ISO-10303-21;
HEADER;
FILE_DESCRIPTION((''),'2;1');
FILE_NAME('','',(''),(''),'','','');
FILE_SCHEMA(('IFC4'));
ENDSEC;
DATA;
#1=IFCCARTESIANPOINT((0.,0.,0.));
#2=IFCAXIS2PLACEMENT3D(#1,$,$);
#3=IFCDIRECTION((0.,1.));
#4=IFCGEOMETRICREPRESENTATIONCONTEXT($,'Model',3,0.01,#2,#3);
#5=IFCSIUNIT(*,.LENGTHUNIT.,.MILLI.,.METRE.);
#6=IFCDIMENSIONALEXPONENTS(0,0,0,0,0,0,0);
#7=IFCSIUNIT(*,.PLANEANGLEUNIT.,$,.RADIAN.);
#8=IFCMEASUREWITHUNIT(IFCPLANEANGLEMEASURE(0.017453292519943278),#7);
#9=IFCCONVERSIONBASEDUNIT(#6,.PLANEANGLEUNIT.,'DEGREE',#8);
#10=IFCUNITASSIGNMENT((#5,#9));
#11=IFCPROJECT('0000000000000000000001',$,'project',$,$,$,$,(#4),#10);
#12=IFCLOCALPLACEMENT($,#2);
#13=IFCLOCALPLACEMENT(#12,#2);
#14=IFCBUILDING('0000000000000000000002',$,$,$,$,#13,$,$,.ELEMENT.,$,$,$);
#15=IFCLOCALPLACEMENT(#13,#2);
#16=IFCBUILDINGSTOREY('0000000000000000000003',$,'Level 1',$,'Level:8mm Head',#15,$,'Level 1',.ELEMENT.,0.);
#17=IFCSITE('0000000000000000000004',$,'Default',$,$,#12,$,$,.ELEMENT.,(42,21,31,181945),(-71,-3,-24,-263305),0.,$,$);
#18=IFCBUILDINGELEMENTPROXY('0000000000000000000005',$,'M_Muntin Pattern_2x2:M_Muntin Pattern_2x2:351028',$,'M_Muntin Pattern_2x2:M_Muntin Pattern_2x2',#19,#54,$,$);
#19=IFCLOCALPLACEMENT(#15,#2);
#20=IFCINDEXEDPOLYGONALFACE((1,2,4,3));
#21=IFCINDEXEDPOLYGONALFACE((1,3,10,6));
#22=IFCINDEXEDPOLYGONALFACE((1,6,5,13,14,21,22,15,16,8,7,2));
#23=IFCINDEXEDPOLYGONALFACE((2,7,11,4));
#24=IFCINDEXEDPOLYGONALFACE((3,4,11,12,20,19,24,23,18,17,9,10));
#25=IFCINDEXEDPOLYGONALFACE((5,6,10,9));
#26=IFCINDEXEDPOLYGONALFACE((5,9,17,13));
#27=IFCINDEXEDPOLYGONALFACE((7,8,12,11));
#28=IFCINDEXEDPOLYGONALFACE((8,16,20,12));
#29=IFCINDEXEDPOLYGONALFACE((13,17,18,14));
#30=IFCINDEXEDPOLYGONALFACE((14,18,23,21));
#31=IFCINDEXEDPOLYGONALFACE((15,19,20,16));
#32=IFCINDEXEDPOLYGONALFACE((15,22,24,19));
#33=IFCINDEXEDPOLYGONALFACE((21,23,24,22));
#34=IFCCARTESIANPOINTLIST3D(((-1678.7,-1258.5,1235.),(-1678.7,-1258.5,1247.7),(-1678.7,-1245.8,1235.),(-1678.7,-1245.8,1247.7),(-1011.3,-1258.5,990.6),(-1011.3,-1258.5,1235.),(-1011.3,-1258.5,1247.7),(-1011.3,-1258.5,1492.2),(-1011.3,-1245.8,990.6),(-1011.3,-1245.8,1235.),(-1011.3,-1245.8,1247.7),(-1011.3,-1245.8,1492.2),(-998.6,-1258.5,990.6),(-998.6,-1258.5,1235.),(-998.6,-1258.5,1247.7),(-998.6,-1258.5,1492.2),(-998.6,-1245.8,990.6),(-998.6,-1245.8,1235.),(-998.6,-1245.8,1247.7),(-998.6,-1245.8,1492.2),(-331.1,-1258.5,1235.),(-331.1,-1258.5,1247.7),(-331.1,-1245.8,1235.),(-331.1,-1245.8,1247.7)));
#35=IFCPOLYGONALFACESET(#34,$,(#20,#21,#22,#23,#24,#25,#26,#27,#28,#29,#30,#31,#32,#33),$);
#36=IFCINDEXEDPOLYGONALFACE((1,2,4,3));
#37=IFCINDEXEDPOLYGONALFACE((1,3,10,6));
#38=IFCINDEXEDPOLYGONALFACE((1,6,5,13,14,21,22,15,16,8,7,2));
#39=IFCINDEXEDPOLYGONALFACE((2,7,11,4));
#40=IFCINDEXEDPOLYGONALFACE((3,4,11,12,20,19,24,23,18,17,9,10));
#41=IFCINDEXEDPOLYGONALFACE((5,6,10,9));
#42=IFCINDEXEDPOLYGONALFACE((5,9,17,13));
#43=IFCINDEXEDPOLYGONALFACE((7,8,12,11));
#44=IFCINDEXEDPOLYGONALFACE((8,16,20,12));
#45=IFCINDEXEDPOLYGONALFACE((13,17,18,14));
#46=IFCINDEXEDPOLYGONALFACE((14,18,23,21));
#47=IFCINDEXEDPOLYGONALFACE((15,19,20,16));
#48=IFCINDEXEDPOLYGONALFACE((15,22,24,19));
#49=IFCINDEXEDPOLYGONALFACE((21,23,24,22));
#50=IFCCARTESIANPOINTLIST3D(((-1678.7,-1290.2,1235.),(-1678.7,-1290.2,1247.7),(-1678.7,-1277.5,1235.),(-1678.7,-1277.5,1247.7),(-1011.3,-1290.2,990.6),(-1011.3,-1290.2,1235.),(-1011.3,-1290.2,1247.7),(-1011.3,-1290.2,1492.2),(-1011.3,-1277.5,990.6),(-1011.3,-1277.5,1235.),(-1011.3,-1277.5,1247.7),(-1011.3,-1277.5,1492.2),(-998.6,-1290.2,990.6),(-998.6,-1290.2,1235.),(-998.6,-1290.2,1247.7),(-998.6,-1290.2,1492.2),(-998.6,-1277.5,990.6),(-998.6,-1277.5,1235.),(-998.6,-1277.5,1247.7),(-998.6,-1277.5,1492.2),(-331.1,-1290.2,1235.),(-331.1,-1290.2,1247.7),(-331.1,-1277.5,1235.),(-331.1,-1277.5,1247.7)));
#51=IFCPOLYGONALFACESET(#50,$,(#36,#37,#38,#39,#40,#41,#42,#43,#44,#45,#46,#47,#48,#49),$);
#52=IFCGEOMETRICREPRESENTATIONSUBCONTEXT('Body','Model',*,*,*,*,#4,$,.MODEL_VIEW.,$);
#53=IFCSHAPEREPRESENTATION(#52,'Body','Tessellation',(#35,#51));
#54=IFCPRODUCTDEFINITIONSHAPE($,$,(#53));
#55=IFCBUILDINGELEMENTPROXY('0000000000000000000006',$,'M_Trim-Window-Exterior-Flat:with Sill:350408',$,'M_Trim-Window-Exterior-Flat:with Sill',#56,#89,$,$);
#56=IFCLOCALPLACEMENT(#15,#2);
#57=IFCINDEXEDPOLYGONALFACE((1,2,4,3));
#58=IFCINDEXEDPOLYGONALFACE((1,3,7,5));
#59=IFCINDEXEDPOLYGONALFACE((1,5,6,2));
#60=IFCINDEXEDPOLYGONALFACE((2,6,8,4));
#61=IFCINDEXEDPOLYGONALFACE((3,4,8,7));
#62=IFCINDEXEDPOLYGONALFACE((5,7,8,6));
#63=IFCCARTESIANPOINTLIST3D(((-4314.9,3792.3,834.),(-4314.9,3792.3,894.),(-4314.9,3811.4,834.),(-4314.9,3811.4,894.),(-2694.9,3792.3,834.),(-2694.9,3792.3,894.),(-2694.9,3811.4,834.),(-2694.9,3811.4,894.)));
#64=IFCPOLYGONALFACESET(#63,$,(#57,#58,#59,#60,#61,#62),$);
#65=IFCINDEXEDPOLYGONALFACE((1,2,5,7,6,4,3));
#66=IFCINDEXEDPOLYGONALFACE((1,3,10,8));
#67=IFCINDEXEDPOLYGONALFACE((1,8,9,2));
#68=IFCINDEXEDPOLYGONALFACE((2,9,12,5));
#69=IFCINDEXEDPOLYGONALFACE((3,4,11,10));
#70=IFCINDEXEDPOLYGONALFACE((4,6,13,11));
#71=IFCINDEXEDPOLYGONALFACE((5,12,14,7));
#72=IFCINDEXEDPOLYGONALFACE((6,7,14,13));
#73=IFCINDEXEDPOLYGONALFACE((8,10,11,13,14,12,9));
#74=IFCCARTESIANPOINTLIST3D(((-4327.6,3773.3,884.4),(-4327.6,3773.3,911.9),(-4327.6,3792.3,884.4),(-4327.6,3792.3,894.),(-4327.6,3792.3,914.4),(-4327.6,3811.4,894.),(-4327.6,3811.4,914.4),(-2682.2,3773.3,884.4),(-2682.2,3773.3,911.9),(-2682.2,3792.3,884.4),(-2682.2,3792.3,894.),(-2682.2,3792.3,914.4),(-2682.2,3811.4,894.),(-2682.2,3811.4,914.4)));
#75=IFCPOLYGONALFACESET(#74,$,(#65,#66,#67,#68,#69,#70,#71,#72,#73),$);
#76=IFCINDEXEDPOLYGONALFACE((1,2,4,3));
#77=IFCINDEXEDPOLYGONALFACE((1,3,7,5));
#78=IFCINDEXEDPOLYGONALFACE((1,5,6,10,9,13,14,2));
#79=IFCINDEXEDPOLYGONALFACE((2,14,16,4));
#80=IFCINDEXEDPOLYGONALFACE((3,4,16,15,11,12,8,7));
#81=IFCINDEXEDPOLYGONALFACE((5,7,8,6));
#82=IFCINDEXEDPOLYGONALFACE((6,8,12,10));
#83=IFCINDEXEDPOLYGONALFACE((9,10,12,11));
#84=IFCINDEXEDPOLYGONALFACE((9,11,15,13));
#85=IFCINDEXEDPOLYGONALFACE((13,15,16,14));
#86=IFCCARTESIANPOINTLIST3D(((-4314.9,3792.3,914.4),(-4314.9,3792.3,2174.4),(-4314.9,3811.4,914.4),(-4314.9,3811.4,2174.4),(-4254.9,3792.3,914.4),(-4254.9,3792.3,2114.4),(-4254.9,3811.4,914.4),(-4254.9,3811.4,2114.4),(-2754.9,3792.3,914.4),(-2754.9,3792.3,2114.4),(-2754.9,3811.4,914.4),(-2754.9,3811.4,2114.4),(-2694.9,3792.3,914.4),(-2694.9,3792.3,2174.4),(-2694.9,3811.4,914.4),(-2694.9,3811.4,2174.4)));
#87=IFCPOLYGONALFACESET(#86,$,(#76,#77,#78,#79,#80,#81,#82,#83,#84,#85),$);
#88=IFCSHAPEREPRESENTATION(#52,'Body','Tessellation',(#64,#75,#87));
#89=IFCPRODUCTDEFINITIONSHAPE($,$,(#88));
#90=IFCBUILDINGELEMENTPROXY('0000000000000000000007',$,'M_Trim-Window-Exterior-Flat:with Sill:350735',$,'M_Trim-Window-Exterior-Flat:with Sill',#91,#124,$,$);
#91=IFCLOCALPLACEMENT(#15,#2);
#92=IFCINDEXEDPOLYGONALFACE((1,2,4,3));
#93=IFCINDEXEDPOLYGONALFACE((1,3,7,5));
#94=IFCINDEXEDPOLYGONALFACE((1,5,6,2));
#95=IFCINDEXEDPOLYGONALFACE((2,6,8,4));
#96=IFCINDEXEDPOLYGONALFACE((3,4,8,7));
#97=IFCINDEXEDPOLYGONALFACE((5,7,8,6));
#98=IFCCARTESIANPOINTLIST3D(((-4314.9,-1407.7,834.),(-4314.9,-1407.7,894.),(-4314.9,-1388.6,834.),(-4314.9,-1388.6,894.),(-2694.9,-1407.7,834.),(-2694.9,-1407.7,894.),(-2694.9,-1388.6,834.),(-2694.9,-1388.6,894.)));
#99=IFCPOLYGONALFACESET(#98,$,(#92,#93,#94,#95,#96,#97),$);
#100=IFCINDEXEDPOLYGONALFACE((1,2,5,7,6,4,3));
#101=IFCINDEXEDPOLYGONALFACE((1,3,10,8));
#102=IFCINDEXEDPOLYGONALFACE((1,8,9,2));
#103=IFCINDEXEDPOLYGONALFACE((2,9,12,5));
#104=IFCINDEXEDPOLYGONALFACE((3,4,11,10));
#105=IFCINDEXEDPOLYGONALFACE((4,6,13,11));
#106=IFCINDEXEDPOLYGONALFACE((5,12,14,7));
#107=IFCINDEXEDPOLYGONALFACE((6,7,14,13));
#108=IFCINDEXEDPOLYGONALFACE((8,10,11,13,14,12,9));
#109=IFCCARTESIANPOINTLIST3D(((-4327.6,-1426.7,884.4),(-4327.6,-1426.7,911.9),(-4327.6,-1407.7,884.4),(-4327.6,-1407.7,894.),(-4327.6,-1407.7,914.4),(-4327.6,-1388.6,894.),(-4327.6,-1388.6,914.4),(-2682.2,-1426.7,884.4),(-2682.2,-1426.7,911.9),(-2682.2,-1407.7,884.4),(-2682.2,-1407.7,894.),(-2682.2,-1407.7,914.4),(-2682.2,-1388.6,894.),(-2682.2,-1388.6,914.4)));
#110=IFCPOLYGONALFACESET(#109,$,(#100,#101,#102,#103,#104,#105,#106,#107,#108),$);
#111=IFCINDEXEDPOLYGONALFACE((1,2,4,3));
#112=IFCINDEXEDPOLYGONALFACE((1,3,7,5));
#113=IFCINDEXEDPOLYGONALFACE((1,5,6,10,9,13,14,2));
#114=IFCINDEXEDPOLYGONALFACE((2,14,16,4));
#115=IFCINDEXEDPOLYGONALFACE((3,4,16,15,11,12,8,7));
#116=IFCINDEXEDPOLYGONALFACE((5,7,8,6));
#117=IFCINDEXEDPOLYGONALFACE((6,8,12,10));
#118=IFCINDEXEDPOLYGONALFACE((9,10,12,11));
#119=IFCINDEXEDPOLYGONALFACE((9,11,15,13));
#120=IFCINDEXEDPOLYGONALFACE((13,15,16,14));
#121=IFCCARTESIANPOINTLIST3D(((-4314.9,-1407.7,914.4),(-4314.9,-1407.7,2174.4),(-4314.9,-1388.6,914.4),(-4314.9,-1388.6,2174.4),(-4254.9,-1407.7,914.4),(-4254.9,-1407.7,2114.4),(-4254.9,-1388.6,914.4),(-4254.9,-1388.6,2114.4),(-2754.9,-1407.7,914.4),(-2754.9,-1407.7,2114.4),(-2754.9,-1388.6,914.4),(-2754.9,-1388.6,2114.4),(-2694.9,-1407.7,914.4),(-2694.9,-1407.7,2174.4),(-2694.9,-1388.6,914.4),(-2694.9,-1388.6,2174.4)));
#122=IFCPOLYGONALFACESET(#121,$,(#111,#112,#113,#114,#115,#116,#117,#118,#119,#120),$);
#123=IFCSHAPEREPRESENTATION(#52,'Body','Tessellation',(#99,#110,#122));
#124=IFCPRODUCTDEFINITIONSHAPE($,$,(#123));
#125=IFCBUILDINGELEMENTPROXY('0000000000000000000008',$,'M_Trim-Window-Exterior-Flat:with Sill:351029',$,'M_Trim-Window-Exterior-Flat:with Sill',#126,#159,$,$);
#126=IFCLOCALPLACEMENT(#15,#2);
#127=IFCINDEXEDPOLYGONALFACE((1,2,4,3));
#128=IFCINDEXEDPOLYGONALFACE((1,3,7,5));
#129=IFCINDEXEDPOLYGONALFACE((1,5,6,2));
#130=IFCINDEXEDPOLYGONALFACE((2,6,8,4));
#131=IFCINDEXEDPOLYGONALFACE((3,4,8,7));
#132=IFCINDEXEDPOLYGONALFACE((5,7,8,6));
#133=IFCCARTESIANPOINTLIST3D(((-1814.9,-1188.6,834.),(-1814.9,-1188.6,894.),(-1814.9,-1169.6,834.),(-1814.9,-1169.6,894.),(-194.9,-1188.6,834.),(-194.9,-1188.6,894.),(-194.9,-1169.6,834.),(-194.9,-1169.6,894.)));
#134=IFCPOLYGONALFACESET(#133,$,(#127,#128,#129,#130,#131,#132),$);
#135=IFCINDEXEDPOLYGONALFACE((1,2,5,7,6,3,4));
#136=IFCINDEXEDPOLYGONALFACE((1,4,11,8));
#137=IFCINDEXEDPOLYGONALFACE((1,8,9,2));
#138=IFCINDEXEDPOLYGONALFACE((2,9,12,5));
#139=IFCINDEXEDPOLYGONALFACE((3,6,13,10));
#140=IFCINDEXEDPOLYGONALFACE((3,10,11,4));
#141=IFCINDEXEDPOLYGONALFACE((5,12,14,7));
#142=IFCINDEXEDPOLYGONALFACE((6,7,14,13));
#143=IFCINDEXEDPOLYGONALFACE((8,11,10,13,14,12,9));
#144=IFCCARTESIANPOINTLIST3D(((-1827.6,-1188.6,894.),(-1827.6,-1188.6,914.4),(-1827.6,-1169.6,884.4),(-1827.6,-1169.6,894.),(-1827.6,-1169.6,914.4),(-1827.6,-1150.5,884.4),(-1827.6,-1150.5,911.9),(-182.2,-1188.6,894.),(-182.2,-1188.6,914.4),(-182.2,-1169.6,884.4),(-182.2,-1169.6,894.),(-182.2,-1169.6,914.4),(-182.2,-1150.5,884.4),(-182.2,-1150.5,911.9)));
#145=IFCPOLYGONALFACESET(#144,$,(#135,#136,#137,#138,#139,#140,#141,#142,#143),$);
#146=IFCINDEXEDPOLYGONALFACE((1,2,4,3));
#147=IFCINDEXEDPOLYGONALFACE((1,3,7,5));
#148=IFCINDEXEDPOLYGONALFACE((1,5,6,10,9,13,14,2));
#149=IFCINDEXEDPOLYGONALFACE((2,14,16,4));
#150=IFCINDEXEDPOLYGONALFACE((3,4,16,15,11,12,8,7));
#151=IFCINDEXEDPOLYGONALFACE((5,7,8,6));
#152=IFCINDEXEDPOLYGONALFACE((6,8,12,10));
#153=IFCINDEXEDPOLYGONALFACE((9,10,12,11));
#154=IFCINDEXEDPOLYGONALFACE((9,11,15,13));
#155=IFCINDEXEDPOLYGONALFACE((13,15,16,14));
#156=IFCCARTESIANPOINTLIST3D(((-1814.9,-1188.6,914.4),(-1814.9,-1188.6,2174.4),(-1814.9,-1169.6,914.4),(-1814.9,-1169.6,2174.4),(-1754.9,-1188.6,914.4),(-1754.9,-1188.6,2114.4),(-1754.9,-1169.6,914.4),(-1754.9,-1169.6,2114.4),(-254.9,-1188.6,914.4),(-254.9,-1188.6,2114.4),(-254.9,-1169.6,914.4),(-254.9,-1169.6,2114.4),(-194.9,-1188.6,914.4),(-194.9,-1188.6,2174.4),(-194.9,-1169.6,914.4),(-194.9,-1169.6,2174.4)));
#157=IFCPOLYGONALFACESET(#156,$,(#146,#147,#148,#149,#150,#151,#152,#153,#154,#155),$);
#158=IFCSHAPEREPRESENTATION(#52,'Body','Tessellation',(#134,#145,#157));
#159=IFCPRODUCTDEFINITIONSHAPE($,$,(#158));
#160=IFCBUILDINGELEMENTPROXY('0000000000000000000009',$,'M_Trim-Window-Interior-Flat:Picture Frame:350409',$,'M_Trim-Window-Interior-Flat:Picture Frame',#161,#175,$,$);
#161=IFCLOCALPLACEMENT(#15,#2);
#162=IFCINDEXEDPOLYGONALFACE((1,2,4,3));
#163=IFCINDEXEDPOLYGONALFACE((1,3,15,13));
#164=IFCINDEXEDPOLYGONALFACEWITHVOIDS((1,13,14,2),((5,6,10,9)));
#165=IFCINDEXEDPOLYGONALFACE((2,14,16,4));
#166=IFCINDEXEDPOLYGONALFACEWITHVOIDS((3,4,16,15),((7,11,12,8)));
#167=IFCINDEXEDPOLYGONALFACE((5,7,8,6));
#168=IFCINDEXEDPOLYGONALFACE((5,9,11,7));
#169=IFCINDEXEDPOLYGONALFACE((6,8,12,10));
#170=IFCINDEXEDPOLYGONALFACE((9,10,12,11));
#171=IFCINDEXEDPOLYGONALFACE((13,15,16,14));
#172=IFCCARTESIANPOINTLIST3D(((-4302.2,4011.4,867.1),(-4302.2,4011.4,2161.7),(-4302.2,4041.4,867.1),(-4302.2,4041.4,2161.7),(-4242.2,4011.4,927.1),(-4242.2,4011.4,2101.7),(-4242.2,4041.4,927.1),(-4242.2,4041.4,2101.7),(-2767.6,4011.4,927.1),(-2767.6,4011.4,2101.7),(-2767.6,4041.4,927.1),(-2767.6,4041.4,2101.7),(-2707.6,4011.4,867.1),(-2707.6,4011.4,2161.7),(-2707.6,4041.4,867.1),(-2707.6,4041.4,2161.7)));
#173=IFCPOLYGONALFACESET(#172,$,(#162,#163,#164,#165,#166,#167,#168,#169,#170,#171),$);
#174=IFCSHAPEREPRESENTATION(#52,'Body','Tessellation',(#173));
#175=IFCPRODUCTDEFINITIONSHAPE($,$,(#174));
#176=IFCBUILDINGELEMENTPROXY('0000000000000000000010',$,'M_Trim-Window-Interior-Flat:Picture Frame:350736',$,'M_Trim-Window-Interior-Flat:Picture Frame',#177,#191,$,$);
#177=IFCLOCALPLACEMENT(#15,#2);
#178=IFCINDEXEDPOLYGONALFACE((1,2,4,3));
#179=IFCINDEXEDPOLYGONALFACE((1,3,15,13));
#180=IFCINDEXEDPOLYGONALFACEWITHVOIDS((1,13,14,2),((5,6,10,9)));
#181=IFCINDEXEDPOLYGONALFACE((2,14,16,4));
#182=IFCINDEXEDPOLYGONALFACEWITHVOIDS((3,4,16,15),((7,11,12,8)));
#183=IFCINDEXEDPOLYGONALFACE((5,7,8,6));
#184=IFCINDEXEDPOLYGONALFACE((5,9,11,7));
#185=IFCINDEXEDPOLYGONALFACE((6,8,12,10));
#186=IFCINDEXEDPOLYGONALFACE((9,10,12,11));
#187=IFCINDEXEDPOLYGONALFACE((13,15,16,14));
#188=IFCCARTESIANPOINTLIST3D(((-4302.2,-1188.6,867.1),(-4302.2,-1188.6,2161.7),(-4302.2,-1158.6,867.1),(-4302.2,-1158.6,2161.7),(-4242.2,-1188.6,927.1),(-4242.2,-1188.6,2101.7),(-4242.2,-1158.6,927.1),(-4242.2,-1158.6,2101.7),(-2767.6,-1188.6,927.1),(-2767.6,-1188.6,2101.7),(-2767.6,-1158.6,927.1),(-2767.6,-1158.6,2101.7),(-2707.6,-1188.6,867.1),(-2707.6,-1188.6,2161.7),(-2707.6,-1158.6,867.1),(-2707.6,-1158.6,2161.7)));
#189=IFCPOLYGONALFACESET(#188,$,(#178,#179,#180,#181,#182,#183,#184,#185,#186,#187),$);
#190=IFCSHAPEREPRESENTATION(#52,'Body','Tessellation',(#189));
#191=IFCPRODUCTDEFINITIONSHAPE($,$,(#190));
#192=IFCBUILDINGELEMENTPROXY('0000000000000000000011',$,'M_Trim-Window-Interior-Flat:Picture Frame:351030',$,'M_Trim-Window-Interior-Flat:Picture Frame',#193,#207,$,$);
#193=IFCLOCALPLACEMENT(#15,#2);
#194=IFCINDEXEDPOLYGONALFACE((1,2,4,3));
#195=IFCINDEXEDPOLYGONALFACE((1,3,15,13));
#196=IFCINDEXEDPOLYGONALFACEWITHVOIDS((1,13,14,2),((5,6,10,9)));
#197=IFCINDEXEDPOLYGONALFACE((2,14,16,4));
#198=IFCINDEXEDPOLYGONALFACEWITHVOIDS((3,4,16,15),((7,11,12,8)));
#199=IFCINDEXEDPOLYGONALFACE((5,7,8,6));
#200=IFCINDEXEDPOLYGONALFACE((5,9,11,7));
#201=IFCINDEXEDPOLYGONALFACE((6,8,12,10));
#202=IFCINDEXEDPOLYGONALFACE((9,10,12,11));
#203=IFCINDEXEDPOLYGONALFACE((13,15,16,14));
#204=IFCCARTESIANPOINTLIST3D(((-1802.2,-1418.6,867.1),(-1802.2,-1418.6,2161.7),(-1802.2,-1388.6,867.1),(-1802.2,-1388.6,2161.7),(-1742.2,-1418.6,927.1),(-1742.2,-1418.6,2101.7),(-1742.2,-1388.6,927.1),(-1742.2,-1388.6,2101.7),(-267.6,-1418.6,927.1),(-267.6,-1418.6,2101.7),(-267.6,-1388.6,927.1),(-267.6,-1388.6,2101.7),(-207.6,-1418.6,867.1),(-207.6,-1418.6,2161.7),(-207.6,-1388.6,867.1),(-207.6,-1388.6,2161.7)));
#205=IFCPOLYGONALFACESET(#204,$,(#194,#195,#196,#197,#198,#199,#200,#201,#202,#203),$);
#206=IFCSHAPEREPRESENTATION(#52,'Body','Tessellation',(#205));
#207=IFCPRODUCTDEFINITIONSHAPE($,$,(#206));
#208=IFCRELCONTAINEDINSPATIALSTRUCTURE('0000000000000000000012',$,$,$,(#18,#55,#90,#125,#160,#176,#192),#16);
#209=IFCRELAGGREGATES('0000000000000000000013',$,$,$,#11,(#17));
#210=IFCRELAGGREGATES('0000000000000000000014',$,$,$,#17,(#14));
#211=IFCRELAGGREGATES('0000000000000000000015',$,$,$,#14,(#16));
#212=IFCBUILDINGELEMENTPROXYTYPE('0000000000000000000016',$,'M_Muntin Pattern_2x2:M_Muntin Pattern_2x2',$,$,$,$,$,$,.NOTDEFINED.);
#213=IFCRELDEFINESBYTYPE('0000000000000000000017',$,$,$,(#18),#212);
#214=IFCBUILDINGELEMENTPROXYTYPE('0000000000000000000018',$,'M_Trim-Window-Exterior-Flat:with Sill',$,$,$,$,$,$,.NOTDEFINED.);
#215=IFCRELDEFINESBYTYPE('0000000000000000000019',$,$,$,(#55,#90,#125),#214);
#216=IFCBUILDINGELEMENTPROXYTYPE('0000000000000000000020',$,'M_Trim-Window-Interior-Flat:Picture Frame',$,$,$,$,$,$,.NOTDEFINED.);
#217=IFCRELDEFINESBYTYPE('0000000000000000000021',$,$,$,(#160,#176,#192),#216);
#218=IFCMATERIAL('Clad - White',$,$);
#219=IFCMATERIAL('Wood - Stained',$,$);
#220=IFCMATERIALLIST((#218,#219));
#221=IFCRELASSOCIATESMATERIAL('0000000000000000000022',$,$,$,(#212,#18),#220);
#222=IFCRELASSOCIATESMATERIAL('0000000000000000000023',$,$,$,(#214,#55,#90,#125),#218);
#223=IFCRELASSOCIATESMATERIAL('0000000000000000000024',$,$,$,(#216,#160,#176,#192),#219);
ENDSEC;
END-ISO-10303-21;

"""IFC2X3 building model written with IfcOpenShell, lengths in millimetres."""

from ifc_helpers import new_model, entity, si_unit, converted_unit, direction, frame, frame_2d, origin, place, context, subcontext, project, spatial, polyline, rectangle, outline, extrude, source, transform, mapped, material, material_list, type_object, type_shapes, element, save


model = new_model("IFC2X3")

# Units and contexts
model_context = context("Model", 3, precision=0.01, world=origin(), true_north=direction((0.0, 1.0)))
body_context = subcontext(model_context, "Body", "Model", "MODEL_VIEW")
ifc_project = project(units=[si_unit("LENGTHUNIT", "METRE", prefix="MILLI"), converted_unit("PLANEANGLEUNIT", "DEGREE", entity("IfcPlaneAngleMeasure", 0.017453292519943278), si_unit("PLANEANGLEUNIT", "RADIAN"), dimensions=[0, 0, 0, 0, 0, 0, 0])], contexts=[model_context])

# Site, building, storey
site_placement = place(None, origin())
site = spatial("IfcSite", under=ifc_project, at=site_placement, Name="Default", CompositionType="ELEMENT", RefLatitude=(42, 21, 31, 181945), RefLongitude=(-71, -3, -24, -263305), RefElevation=0.0)
building_placement = place(site_placement, origin())
building = spatial("IfcBuilding", under=site, at=building_placement, CompositionType="ELEMENT")
storey_placement = place(building_placement, origin())
storey = spatial("IfcBuildingStorey", under=building, at=storey_placement, Name="Level 1", ObjectType="Level:8mm Head", LongName="Level 1", CompositionType="ELEMENT", Elevation=0.0)

# Shared definitions
ifc_material_1 = material(Name="Wood - Stained")

# Building element proxies
ifc_material_2 = material(Name="Clad - White")
ifc_material_list_1 = material_list([ifc_material_2, ifc_material_1])
building_element_proxy_type_1 = type_object("IfcBuildingElementProxyType", Name="M_Muntin Pattern_2x2:M_Muntin Pattern_2x2", PredefinedType="NOTDEFINED", material=ifc_material_list_1)
shared_shape_1 = source(origin(), body_context, "Body", "SweptSolid", [
    extrude(outline(polyline([(6.4, -6.4), (250.8, -6.4), (250.8, 6.3), (6.4, 6.3), (6.4, 673.8), (-6.3, 673.8), (-6.3, 6.3), (-250.8, 6.3), (-250.8, -6.4), (-6.3, -6.4), (-6.3, -673.8), (6.4, -673.8), (6.4, -6.4)])), frame((0.0, 9.5, 250.8), z_axis=(0.0, 1.0, 0.0), x_axis=(0.0, 0.0, 1.0)), (0.0, 0.0, 1.0), 12.7),
    extrude(outline(polyline([(6.4, -6.4), (250.8, -6.4), (250.8, 6.3), (6.4, 6.3), (6.4, 673.8), (-6.3, 673.8), (-6.3, 6.3), (-250.8, 6.3), (-250.8, -6.4), (-6.3, -6.4), (-6.3, -673.8), (6.4, -673.8), (6.4, -6.4)])), frame((0.0, -22.2, 250.8), z_axis=(0.0, 1.0, 0.0), x_axis=(0.0, 0.0, 1.0)), (0.0, 0.0, 1.0), 12.7),
])
type_shapes(building_element_proxy_type_1, [shared_shape_1])
for number, where, name in (
    (1, (-1004.9, -1268.0, 990.6), "M_Muntin Pattern_2x2:M_Muntin Pattern_2x2:351028"),
):
    element("IfcBuildingElementProxy", number, at=place(storey_placement, frame(where)), inside=storey, type_object=building_element_proxy_type_1, material=ifc_material_list_1, Name=name, ObjectType="M_Muntin Pattern_2x2:M_Muntin Pattern_2x2", context=body_context, shape_type="MappedRepresentation", body=[
        mapped(shared_shape_1, transform((0.0, 0.0, 0.0), scale=1.0)),
    ])
building_element_proxy_type_2 = type_object("IfcBuildingElementProxyType", Name="M_Trim-Window-Exterior-Flat:with Sill", PredefinedType="NOTDEFINED", material=ifc_material_2)
shared_shape_2 = source(origin(), body_context, "Body", "SweptSolid", [
    extrude(rectangle(XDim=1620.0, YDim=60.0, at=frame_2d((0.0, 0.0), x_axis=(1.0, 0.0))), frame((0.0, -1250.4, 0.0), z_axis=(0.0, 0.0, 1.0), x_axis=(-1.0, 0.0, 0.0)), (0.0, 0.0, 1.0), 19.0),
    extrude(outline(polyline([(-19.0, -15.2), (0.0, -15.2), (0.0, -5.7), (19.0, -5.7), (19.0, 14.8), (0.0, 14.8), (-19.0, 12.3), (-19.0, -15.2)])), frame((-822.7, -1214.8, 19.0), z_axis=(1.0, 0.0, 0.0), x_axis=(0.0, 0.0, -1.0)), (0.0, 0.0, 1.0), 1645.4),
    extrude(outline(polyline([(-645.0, -810.0), (615.0, -810.0), (615.0, -750.0), (-585.0, -750.0), (-585.0, 750.0), (615.0, 750.0), (615.0, 810.0), (-645.0, 810.0), (-645.0, -810.0)])), frame((0.0, -585.0, 0.0), z_axis=(0.0, 0.0, 1.0), x_axis=(0.0, -1.0, 0.0)), (0.0, 0.0, 1.0), 19.0),
])
type_shapes(building_element_proxy_type_2, [shared_shape_2])
for number, where, z_axis, x_axis, name in (
    (2, (-3504.9, 3811.4, 2114.4), (0.0, -1.0, 0.0), (1.0, 0.0, 0.0), "M_Trim-Window-Exterior-Flat:with Sill:350408"),
    (3, (-3504.9, -1388.6, 2114.4), (0.0, -1.0, 0.0), (1.0, 0.0, 0.0), "M_Trim-Window-Exterior-Flat:with Sill:350735"),
    (4, (-1004.9, -1188.6, 2114.4), (0.0, 1.0, 0.0), (-1.0, 0.0, 0.0), "M_Trim-Window-Exterior-Flat:with Sill:351029"),
):
    element("IfcBuildingElementProxy", number, at=place(storey_placement, frame(where, z_axis=z_axis, x_axis=x_axis)), inside=storey, type_object=building_element_proxy_type_2, material=ifc_material_2, Name=name, ObjectType="M_Trim-Window-Exterior-Flat:with Sill", context=body_context, shape_type="MappedRepresentation", body=[
        mapped(shared_shape_2, transform((0.0, 0.0, 0.0), scale=1.0)),
    ])
building_element_proxy_type_3 = type_object("IfcBuildingElementProxyType", Name="M_Trim-Window-Interior-Flat:Picture Frame", PredefinedType="NOTDEFINED", material=ifc_material_1)
shared_shape_3 = source(origin(), body_context, "Body", "SweptSolid", [
    extrude(outline(polyline([(-797.3, -647.3), (797.3, -647.3), (797.3, 647.3), (-797.3, 647.3), (-797.3, -647.3)]), holes=[polyline([(-737.3, -587.3), (-737.3, 587.3), (737.3, 587.3), (737.3, -587.3), (-737.3, -587.3)])]), frame((0.0, -600.0, 0.0), z_axis=(0.0, 0.0, 1.0), x_axis=(-1.0, 0.0, 0.0)), (0.0, 0.0, 1.0), 30.0),
])
type_shapes(building_element_proxy_type_3, [shared_shape_3])
for number, where, z_axis, x_axis, name in (
    (5, (-3504.9, 4011.4, 2114.4), (0.0, 1.0, 0.0), (-1.0, 0.0, 0.0), "M_Trim-Window-Interior-Flat:Picture Frame:350409"),
    (6, (-3504.9, -1188.6, 2114.4), (0.0, 1.0, 0.0), (-1.0, 0.0, 0.0), "M_Trim-Window-Interior-Flat:Picture Frame:350736"),
    (7, (-1004.9, -1388.6, 2114.4), (0.0, -1.0, 0.0), (1.0, 0.0, 0.0), "M_Trim-Window-Interior-Flat:Picture Frame:351030"),
):
    element("IfcBuildingElementProxy", number, at=place(storey_placement, frame(where, z_axis=z_axis, x_axis=x_axis)), inside=storey, type_object=building_element_proxy_type_3, material=ifc_material_1, Name=name, ObjectType="M_Trim-Window-Interior-Flat:Picture Frame", context=body_context, shape_type="MappedRepresentation", body=[
        mapped(shared_shape_3, transform((0.0, 0.0, 0.0), scale=1.0)),
    ])

save(model, "model.ifc")
